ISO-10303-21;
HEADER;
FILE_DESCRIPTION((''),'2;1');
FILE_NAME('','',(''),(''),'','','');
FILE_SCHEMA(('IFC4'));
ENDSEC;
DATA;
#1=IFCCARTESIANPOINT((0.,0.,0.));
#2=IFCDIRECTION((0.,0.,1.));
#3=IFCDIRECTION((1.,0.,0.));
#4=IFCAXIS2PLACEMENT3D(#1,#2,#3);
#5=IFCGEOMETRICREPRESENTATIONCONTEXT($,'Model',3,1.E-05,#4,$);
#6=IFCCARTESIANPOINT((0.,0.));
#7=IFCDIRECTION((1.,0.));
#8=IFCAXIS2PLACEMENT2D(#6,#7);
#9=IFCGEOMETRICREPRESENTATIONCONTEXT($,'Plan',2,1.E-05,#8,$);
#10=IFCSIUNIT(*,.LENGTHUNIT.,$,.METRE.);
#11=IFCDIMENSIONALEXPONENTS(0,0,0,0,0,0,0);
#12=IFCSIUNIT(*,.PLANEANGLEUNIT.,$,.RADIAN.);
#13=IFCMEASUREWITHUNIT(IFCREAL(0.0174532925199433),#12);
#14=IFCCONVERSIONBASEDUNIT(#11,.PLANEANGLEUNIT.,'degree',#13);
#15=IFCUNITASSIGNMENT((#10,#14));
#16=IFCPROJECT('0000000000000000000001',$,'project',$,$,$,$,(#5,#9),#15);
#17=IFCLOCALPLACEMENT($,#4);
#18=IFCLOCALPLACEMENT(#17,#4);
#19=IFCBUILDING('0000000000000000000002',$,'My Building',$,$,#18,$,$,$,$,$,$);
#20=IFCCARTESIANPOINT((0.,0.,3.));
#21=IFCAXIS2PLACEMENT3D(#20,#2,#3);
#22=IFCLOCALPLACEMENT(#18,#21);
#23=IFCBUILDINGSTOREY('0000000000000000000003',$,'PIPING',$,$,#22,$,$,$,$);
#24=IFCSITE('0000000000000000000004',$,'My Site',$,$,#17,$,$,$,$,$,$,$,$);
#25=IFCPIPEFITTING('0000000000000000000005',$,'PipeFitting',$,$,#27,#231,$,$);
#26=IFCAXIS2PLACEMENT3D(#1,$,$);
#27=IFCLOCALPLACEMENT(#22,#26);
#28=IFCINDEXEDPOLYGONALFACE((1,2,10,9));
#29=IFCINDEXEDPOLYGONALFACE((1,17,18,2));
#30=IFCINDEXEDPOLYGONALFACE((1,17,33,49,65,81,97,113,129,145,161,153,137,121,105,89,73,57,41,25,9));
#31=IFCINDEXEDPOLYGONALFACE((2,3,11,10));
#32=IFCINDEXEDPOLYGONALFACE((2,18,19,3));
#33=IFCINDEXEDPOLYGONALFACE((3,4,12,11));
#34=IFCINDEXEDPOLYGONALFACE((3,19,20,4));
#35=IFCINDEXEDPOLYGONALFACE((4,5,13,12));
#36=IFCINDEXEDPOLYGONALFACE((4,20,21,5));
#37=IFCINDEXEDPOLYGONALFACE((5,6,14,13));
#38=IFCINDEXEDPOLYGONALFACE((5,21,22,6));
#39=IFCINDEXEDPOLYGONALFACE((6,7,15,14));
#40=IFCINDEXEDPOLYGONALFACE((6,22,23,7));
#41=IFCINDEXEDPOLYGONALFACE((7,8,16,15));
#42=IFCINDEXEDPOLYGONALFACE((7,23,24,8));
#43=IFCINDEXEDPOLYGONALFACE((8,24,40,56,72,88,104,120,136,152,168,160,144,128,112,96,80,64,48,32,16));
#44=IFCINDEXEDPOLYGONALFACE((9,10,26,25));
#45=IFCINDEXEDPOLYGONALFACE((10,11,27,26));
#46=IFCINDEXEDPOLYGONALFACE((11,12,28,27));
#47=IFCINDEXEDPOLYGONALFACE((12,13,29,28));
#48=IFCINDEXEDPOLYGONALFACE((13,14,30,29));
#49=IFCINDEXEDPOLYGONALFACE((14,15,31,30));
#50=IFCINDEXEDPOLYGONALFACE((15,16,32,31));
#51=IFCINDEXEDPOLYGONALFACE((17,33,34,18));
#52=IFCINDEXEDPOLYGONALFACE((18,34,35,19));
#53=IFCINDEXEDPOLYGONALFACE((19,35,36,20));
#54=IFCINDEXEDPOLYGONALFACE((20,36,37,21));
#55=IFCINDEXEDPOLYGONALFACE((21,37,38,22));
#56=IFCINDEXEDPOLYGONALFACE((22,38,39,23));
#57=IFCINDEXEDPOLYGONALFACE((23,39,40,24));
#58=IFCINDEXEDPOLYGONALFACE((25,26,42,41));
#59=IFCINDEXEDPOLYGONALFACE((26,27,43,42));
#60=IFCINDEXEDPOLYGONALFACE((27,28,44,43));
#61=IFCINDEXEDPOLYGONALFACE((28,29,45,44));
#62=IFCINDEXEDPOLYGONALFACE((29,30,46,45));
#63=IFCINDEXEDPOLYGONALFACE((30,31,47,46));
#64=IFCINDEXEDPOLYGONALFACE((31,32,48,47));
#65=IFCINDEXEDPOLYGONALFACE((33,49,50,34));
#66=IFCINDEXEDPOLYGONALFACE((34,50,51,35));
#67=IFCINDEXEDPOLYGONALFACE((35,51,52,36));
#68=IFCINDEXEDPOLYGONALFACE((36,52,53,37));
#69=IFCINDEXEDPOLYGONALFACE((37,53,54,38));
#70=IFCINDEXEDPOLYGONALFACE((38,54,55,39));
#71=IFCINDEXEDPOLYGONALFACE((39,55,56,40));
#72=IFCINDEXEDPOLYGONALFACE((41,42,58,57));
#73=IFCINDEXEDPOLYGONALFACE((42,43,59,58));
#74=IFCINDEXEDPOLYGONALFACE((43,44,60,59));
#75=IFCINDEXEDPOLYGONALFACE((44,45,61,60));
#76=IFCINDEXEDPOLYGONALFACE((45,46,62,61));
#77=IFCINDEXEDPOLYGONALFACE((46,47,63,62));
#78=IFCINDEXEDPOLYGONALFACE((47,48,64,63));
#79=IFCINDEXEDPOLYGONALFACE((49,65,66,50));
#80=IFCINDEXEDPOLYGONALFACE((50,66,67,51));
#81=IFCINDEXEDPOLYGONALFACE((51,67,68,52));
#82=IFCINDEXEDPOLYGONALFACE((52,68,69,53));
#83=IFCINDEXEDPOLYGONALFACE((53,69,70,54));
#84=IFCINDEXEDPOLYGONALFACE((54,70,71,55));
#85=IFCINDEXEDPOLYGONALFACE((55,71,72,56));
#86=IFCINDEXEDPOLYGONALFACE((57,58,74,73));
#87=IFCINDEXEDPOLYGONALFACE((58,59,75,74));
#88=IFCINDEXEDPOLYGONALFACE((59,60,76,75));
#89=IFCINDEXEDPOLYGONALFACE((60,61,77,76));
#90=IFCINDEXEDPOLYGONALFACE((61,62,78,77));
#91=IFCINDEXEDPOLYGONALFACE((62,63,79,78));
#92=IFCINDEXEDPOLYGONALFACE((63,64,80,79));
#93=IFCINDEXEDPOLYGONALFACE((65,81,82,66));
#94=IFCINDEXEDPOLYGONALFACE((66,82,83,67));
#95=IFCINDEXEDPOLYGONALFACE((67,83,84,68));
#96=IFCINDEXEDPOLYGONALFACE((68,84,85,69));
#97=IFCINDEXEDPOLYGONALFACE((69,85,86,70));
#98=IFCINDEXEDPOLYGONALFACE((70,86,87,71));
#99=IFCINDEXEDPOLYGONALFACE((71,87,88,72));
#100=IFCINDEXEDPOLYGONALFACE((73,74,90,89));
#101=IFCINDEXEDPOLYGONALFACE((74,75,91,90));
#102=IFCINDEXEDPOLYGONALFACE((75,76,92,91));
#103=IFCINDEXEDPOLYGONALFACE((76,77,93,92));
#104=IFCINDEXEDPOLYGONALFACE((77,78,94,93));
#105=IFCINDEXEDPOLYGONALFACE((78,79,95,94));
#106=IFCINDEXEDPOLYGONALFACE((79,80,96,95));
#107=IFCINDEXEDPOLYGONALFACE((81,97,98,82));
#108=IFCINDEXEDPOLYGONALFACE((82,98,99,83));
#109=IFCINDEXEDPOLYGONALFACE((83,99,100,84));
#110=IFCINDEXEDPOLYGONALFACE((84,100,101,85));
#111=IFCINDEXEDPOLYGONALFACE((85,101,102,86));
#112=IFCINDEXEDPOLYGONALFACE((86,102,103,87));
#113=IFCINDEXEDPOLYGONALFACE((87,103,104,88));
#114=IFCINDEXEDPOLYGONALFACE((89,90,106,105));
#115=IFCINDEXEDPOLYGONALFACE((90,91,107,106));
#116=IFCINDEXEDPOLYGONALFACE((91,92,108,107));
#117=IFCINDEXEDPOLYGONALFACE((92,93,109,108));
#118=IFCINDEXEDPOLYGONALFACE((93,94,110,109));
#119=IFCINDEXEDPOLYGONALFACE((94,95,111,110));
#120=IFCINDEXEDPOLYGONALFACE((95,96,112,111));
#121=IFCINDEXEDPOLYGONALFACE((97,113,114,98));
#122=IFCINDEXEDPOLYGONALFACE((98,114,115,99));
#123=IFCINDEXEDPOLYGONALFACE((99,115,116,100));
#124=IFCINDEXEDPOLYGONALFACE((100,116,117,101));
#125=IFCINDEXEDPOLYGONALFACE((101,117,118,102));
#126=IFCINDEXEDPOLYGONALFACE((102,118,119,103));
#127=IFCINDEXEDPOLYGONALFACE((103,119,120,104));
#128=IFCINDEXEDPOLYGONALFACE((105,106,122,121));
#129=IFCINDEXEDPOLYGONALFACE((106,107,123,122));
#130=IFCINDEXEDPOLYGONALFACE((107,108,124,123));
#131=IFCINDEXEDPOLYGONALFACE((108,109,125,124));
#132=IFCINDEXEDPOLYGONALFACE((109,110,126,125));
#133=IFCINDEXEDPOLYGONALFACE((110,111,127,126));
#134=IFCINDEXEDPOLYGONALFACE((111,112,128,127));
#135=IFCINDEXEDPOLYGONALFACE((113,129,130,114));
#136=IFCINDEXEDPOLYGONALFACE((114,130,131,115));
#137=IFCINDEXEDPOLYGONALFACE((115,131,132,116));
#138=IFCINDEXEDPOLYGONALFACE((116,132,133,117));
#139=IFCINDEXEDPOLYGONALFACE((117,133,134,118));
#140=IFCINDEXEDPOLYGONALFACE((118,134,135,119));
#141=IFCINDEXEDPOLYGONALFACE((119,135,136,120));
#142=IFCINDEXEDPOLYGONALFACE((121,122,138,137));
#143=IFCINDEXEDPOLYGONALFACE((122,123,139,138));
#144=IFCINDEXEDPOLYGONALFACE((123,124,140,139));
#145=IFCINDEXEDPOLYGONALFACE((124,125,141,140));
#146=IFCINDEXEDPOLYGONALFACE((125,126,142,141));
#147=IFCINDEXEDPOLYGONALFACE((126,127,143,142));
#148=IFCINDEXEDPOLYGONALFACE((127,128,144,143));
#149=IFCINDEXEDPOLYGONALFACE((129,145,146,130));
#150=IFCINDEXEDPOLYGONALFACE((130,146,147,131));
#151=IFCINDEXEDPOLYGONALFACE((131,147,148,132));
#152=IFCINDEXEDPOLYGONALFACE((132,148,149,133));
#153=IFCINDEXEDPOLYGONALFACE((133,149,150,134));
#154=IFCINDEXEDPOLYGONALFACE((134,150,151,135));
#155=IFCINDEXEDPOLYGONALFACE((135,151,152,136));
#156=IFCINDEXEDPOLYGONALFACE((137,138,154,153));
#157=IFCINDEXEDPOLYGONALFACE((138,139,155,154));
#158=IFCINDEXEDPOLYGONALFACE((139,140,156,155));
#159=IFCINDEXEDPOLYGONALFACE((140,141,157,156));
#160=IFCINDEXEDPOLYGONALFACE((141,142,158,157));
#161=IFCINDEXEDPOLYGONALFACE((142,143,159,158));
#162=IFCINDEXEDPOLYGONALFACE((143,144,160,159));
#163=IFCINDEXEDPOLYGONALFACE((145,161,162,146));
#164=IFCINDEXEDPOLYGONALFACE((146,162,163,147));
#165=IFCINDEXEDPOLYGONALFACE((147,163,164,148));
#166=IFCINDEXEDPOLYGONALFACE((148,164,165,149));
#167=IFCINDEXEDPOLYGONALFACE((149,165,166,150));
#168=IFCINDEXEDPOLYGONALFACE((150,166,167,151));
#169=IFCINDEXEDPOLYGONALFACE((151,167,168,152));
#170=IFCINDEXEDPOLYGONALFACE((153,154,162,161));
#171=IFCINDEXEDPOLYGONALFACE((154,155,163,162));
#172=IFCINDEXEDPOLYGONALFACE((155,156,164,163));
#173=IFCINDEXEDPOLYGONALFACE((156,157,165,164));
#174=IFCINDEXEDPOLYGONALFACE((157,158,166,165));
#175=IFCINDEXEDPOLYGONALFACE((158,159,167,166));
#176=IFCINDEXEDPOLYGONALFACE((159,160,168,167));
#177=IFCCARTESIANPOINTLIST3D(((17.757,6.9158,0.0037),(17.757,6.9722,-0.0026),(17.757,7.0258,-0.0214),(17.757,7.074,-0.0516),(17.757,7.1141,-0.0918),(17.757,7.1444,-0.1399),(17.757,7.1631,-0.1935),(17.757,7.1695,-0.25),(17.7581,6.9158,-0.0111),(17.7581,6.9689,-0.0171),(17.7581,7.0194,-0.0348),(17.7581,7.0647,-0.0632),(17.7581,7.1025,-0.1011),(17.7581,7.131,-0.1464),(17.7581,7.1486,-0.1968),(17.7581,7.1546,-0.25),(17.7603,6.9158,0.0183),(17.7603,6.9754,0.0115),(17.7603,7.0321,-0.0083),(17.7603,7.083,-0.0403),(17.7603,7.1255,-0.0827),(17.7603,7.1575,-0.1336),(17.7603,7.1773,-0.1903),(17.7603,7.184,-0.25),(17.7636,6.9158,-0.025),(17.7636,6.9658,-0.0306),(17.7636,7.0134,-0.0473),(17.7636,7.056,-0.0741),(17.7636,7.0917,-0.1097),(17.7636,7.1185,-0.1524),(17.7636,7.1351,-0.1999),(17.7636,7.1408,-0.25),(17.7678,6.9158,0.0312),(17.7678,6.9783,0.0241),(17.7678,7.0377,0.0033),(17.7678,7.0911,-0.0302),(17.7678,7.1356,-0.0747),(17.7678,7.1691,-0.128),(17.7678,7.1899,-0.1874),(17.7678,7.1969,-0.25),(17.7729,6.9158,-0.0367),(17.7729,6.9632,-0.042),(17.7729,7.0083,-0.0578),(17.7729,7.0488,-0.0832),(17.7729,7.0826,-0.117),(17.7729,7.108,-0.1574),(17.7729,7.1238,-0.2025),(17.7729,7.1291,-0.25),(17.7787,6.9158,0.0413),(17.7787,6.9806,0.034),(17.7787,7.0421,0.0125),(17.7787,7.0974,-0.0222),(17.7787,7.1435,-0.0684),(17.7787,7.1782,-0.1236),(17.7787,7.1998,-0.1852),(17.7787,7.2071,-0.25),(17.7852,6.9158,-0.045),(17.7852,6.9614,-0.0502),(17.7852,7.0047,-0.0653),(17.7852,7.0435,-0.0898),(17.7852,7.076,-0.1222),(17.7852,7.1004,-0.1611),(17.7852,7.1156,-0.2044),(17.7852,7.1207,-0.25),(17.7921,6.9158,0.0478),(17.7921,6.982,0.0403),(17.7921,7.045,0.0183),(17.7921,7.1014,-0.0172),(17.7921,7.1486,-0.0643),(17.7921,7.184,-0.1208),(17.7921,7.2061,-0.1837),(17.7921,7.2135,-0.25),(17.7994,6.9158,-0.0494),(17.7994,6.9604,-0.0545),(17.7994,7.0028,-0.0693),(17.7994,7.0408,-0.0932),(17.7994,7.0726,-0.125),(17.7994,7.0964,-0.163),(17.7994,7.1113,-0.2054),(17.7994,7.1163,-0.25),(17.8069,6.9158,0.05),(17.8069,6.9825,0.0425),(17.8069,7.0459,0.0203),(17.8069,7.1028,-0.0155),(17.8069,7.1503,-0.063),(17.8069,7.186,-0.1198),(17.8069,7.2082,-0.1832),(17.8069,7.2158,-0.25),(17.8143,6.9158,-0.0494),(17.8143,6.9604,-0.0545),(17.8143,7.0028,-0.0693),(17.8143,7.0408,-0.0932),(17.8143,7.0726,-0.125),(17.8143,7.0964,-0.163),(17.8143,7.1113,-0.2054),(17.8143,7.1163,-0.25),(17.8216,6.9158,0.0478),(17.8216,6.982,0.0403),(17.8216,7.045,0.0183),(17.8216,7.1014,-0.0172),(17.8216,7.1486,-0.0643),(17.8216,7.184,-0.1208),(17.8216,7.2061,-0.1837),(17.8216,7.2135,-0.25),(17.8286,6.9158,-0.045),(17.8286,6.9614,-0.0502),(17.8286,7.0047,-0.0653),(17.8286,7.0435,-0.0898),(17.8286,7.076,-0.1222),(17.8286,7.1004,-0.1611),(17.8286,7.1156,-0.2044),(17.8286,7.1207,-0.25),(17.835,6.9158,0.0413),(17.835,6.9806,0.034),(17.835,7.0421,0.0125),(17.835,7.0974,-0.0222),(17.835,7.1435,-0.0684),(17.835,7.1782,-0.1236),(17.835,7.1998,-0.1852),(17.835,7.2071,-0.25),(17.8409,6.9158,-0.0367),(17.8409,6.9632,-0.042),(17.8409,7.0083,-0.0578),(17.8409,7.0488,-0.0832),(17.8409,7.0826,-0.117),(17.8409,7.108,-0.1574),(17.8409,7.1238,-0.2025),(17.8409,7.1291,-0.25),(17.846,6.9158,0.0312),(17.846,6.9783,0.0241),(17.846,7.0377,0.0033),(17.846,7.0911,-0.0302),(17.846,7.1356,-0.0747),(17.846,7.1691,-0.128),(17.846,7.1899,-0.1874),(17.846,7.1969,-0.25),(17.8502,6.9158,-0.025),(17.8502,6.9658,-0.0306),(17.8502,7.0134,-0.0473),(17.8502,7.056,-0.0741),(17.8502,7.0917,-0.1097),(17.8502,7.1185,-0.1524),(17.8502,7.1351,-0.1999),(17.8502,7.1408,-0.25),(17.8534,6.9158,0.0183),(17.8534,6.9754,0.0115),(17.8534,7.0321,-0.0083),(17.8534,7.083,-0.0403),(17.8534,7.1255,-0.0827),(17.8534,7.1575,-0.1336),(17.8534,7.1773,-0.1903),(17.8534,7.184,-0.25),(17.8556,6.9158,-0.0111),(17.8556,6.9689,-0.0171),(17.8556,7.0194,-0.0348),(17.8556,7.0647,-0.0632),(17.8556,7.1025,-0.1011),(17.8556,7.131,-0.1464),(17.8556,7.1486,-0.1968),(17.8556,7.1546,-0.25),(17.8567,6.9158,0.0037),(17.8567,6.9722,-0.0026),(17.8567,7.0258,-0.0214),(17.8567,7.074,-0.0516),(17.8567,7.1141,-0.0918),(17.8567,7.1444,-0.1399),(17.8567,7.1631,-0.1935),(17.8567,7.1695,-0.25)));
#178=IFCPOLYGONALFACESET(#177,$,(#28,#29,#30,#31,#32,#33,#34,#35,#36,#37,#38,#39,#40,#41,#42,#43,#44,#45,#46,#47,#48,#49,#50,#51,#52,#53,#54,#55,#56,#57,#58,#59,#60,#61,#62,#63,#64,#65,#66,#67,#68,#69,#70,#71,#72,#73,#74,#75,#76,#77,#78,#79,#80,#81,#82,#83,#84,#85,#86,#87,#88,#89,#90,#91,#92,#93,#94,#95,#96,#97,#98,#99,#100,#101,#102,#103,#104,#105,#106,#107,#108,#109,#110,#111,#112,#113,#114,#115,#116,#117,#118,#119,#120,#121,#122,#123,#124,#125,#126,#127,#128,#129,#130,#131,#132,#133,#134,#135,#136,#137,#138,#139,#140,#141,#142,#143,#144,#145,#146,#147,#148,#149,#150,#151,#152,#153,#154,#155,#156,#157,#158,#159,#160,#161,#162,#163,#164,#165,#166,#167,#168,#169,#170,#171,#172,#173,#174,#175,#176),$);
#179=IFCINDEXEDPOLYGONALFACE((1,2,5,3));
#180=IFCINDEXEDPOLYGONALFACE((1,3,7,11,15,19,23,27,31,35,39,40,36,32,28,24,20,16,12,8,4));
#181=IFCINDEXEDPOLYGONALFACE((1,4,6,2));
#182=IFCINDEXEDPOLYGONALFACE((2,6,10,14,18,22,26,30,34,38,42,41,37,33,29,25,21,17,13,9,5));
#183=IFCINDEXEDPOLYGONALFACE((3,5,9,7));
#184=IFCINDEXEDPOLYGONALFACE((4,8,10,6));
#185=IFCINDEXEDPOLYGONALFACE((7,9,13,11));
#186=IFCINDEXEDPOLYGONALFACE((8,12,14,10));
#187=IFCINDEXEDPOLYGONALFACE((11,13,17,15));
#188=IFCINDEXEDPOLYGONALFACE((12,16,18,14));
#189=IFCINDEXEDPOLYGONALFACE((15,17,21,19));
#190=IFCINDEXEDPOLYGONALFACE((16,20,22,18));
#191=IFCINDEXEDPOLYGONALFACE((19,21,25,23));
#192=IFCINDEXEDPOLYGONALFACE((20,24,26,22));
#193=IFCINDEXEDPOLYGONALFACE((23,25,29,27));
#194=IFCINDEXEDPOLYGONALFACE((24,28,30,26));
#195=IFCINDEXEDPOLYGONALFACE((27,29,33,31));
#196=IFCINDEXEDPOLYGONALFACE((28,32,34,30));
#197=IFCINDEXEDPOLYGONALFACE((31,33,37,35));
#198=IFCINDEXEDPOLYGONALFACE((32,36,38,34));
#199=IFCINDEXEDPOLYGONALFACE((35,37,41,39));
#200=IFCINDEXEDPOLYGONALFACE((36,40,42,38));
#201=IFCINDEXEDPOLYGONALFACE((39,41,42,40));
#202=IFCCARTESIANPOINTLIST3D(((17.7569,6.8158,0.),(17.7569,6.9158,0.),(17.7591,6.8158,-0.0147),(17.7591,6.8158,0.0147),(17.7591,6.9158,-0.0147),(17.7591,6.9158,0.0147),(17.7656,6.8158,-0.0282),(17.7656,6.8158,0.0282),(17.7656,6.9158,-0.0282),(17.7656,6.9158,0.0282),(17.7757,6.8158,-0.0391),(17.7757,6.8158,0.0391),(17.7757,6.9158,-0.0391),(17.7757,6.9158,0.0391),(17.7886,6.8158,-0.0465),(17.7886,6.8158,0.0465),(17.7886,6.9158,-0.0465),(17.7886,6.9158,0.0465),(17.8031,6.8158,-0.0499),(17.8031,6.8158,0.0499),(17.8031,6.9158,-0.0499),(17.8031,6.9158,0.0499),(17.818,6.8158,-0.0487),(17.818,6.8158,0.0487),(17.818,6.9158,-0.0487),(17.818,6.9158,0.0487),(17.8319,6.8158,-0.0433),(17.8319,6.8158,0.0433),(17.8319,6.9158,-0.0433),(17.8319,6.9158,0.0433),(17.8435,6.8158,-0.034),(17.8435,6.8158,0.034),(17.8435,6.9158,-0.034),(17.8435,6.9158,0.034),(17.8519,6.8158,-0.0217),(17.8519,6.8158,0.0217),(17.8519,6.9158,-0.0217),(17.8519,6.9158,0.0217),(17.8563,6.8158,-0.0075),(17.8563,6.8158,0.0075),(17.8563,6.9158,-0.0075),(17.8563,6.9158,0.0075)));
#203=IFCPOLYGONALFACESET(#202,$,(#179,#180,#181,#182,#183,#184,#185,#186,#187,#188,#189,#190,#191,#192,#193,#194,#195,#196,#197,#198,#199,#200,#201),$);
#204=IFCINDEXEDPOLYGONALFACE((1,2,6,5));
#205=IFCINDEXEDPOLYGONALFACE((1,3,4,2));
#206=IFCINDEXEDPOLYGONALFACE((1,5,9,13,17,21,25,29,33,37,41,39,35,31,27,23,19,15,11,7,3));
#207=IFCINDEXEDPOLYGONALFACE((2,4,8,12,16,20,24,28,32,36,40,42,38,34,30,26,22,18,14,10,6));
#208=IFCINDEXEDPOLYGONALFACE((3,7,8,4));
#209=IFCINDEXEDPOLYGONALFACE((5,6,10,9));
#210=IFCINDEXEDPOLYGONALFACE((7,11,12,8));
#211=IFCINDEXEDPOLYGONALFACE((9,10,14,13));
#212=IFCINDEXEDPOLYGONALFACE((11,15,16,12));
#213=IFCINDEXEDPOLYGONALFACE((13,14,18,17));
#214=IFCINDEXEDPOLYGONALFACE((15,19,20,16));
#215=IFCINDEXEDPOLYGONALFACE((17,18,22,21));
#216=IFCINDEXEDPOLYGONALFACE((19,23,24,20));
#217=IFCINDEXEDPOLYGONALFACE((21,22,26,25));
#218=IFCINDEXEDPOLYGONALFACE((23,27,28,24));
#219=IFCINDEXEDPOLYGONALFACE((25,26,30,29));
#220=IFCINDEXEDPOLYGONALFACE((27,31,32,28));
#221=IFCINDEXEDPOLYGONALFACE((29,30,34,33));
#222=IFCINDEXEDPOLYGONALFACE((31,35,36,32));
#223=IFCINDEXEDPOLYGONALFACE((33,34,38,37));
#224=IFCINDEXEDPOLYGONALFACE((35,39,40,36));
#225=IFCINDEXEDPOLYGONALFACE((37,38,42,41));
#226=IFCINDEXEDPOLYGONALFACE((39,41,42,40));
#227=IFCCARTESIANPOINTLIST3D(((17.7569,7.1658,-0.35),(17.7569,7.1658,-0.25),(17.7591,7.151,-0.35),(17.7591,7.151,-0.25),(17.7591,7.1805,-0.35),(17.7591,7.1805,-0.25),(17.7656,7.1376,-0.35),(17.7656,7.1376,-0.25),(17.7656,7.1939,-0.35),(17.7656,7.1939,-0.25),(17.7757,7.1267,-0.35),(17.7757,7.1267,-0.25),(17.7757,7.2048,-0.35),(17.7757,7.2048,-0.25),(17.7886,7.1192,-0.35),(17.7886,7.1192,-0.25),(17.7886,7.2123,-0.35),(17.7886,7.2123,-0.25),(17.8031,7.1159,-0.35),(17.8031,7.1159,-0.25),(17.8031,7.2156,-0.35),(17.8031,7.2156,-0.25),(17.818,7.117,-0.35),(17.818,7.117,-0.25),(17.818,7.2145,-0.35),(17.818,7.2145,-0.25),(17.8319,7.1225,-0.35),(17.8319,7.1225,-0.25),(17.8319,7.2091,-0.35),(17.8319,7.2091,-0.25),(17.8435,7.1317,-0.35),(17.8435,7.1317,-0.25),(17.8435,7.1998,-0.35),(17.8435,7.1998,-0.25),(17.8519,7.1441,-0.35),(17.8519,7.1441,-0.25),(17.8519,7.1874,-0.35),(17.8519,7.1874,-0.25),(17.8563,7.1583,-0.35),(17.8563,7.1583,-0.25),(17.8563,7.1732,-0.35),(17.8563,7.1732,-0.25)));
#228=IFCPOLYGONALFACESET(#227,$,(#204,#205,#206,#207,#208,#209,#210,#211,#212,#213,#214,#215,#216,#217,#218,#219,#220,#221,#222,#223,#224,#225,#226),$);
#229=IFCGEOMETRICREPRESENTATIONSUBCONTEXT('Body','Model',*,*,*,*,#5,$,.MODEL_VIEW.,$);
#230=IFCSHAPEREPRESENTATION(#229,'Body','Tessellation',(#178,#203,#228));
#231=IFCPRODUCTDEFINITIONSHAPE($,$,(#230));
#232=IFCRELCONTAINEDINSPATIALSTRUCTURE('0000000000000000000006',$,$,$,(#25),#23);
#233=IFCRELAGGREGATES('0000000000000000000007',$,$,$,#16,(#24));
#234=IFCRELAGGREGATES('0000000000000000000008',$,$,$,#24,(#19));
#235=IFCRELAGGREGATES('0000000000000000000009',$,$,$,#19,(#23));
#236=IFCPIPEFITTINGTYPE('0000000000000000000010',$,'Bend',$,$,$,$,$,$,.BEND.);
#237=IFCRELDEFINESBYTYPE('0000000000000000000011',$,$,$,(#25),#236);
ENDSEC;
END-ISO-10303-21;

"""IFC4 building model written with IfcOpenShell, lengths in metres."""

from ifc_helpers import new_model, entity, si_unit, converted_unit, frame, origin_with_axes, origin_2d_with_axis, place, context, subcontext, project, spatial, circle, extrude, source, transform, mapped, type_object, type_shapes, element, save


model = new_model("IFC4")

# Units and contexts
model_context = context("Model", 3, precision=1e-05, world=origin_with_axes())
plan_context = context("Plan", 2, precision=1e-05, world=origin_2d_with_axis())
body_context = subcontext(model_context, "Body", "Model", "MODEL_VIEW")
ifc_project = project(units=[si_unit("LENGTHUNIT", "METRE"), converted_unit("PLANEANGLEUNIT", "degree", entity("IfcReal", 0.0174532925199433), si_unit("PLANEANGLEUNIT", "RADIAN"), dimensions=[0, 0, 0, 0, 0, 0, 0])], contexts=[model_context, plan_context])

# Site, building, storey
site_placement = place(None, origin_with_axes())
site = spatial("IfcSite", under=ifc_project, at=site_placement, Name="My Site")
building_placement = place(site_placement, origin_with_axes())
building = spatial("IfcBuilding", under=site, at=building_placement, Name="My Building")
storey_placement = place(building_placement, frame((0.0, 0.0, 3.0), z_axis=(0.0, 0.0, 1.0), x_axis=(1.0, 0.0, 0.0)))
storey = spatial("IfcBuildingStorey", under=building, at=storey_placement, Name="PIPING")

# Pipe fitting
pipe_fitting_type = type_object("IfcPipeFittingType", Name="Bend", PredefinedType="BEND")
shared_shape = source(origin_with_axes(), body_context, "Body", "SolidModel", [
    entity("IfcSweptDiskSolid", entity("IfcIndexedPolyCurve", entity("IfcCartesianPointList3D", [[0.0, 0.0, 0.1], [0.0, -0.0732, 0.2768], [0.0, -0.25, 0.35]]), [entity("IfcArcIndex", [1, 2, 3])]), 0.05),
    extrude(circle(Radius=0.05), origin_with_axes(), (0.0, 0.0, 1.0), 0.1),
    extrude(circle(Radius=0.05), frame((0.0, -0.25, 0.35), z_axis=(0.0, -1.0, 0.0), x_axis=(1.0, 0.0, 0.0)), (0.0, 0.0, 1.0), 0.1),
])
type_shapes(pipe_fitting_type, [shared_shape])
for number, where, z_axis, x_axis, name in (
    (1, (17.8069, 6.8158, 0.0), (0.0, 1.0, 0.0), (-1.0, 0.0, 0.0), "PipeFitting"),
):
    element("IfcPipeFitting", number, at=place(storey_placement, frame(where, z_axis=z_axis, x_axis=x_axis)), inside=storey, type_object=pipe_fitting_type, Name=name, context=body_context, shape_type="MappedRepresentation", body=[
        mapped(shared_shape, transform((0.0, 0.0, 0.0), x_axis=(1.0, 0.0, 0.0), y_axis=(0.0, 1.0, 0.0), z_axis=(0.0, 0.0, 1.0), scale=1.0)),
    ])

save(model, "model.ifc")
